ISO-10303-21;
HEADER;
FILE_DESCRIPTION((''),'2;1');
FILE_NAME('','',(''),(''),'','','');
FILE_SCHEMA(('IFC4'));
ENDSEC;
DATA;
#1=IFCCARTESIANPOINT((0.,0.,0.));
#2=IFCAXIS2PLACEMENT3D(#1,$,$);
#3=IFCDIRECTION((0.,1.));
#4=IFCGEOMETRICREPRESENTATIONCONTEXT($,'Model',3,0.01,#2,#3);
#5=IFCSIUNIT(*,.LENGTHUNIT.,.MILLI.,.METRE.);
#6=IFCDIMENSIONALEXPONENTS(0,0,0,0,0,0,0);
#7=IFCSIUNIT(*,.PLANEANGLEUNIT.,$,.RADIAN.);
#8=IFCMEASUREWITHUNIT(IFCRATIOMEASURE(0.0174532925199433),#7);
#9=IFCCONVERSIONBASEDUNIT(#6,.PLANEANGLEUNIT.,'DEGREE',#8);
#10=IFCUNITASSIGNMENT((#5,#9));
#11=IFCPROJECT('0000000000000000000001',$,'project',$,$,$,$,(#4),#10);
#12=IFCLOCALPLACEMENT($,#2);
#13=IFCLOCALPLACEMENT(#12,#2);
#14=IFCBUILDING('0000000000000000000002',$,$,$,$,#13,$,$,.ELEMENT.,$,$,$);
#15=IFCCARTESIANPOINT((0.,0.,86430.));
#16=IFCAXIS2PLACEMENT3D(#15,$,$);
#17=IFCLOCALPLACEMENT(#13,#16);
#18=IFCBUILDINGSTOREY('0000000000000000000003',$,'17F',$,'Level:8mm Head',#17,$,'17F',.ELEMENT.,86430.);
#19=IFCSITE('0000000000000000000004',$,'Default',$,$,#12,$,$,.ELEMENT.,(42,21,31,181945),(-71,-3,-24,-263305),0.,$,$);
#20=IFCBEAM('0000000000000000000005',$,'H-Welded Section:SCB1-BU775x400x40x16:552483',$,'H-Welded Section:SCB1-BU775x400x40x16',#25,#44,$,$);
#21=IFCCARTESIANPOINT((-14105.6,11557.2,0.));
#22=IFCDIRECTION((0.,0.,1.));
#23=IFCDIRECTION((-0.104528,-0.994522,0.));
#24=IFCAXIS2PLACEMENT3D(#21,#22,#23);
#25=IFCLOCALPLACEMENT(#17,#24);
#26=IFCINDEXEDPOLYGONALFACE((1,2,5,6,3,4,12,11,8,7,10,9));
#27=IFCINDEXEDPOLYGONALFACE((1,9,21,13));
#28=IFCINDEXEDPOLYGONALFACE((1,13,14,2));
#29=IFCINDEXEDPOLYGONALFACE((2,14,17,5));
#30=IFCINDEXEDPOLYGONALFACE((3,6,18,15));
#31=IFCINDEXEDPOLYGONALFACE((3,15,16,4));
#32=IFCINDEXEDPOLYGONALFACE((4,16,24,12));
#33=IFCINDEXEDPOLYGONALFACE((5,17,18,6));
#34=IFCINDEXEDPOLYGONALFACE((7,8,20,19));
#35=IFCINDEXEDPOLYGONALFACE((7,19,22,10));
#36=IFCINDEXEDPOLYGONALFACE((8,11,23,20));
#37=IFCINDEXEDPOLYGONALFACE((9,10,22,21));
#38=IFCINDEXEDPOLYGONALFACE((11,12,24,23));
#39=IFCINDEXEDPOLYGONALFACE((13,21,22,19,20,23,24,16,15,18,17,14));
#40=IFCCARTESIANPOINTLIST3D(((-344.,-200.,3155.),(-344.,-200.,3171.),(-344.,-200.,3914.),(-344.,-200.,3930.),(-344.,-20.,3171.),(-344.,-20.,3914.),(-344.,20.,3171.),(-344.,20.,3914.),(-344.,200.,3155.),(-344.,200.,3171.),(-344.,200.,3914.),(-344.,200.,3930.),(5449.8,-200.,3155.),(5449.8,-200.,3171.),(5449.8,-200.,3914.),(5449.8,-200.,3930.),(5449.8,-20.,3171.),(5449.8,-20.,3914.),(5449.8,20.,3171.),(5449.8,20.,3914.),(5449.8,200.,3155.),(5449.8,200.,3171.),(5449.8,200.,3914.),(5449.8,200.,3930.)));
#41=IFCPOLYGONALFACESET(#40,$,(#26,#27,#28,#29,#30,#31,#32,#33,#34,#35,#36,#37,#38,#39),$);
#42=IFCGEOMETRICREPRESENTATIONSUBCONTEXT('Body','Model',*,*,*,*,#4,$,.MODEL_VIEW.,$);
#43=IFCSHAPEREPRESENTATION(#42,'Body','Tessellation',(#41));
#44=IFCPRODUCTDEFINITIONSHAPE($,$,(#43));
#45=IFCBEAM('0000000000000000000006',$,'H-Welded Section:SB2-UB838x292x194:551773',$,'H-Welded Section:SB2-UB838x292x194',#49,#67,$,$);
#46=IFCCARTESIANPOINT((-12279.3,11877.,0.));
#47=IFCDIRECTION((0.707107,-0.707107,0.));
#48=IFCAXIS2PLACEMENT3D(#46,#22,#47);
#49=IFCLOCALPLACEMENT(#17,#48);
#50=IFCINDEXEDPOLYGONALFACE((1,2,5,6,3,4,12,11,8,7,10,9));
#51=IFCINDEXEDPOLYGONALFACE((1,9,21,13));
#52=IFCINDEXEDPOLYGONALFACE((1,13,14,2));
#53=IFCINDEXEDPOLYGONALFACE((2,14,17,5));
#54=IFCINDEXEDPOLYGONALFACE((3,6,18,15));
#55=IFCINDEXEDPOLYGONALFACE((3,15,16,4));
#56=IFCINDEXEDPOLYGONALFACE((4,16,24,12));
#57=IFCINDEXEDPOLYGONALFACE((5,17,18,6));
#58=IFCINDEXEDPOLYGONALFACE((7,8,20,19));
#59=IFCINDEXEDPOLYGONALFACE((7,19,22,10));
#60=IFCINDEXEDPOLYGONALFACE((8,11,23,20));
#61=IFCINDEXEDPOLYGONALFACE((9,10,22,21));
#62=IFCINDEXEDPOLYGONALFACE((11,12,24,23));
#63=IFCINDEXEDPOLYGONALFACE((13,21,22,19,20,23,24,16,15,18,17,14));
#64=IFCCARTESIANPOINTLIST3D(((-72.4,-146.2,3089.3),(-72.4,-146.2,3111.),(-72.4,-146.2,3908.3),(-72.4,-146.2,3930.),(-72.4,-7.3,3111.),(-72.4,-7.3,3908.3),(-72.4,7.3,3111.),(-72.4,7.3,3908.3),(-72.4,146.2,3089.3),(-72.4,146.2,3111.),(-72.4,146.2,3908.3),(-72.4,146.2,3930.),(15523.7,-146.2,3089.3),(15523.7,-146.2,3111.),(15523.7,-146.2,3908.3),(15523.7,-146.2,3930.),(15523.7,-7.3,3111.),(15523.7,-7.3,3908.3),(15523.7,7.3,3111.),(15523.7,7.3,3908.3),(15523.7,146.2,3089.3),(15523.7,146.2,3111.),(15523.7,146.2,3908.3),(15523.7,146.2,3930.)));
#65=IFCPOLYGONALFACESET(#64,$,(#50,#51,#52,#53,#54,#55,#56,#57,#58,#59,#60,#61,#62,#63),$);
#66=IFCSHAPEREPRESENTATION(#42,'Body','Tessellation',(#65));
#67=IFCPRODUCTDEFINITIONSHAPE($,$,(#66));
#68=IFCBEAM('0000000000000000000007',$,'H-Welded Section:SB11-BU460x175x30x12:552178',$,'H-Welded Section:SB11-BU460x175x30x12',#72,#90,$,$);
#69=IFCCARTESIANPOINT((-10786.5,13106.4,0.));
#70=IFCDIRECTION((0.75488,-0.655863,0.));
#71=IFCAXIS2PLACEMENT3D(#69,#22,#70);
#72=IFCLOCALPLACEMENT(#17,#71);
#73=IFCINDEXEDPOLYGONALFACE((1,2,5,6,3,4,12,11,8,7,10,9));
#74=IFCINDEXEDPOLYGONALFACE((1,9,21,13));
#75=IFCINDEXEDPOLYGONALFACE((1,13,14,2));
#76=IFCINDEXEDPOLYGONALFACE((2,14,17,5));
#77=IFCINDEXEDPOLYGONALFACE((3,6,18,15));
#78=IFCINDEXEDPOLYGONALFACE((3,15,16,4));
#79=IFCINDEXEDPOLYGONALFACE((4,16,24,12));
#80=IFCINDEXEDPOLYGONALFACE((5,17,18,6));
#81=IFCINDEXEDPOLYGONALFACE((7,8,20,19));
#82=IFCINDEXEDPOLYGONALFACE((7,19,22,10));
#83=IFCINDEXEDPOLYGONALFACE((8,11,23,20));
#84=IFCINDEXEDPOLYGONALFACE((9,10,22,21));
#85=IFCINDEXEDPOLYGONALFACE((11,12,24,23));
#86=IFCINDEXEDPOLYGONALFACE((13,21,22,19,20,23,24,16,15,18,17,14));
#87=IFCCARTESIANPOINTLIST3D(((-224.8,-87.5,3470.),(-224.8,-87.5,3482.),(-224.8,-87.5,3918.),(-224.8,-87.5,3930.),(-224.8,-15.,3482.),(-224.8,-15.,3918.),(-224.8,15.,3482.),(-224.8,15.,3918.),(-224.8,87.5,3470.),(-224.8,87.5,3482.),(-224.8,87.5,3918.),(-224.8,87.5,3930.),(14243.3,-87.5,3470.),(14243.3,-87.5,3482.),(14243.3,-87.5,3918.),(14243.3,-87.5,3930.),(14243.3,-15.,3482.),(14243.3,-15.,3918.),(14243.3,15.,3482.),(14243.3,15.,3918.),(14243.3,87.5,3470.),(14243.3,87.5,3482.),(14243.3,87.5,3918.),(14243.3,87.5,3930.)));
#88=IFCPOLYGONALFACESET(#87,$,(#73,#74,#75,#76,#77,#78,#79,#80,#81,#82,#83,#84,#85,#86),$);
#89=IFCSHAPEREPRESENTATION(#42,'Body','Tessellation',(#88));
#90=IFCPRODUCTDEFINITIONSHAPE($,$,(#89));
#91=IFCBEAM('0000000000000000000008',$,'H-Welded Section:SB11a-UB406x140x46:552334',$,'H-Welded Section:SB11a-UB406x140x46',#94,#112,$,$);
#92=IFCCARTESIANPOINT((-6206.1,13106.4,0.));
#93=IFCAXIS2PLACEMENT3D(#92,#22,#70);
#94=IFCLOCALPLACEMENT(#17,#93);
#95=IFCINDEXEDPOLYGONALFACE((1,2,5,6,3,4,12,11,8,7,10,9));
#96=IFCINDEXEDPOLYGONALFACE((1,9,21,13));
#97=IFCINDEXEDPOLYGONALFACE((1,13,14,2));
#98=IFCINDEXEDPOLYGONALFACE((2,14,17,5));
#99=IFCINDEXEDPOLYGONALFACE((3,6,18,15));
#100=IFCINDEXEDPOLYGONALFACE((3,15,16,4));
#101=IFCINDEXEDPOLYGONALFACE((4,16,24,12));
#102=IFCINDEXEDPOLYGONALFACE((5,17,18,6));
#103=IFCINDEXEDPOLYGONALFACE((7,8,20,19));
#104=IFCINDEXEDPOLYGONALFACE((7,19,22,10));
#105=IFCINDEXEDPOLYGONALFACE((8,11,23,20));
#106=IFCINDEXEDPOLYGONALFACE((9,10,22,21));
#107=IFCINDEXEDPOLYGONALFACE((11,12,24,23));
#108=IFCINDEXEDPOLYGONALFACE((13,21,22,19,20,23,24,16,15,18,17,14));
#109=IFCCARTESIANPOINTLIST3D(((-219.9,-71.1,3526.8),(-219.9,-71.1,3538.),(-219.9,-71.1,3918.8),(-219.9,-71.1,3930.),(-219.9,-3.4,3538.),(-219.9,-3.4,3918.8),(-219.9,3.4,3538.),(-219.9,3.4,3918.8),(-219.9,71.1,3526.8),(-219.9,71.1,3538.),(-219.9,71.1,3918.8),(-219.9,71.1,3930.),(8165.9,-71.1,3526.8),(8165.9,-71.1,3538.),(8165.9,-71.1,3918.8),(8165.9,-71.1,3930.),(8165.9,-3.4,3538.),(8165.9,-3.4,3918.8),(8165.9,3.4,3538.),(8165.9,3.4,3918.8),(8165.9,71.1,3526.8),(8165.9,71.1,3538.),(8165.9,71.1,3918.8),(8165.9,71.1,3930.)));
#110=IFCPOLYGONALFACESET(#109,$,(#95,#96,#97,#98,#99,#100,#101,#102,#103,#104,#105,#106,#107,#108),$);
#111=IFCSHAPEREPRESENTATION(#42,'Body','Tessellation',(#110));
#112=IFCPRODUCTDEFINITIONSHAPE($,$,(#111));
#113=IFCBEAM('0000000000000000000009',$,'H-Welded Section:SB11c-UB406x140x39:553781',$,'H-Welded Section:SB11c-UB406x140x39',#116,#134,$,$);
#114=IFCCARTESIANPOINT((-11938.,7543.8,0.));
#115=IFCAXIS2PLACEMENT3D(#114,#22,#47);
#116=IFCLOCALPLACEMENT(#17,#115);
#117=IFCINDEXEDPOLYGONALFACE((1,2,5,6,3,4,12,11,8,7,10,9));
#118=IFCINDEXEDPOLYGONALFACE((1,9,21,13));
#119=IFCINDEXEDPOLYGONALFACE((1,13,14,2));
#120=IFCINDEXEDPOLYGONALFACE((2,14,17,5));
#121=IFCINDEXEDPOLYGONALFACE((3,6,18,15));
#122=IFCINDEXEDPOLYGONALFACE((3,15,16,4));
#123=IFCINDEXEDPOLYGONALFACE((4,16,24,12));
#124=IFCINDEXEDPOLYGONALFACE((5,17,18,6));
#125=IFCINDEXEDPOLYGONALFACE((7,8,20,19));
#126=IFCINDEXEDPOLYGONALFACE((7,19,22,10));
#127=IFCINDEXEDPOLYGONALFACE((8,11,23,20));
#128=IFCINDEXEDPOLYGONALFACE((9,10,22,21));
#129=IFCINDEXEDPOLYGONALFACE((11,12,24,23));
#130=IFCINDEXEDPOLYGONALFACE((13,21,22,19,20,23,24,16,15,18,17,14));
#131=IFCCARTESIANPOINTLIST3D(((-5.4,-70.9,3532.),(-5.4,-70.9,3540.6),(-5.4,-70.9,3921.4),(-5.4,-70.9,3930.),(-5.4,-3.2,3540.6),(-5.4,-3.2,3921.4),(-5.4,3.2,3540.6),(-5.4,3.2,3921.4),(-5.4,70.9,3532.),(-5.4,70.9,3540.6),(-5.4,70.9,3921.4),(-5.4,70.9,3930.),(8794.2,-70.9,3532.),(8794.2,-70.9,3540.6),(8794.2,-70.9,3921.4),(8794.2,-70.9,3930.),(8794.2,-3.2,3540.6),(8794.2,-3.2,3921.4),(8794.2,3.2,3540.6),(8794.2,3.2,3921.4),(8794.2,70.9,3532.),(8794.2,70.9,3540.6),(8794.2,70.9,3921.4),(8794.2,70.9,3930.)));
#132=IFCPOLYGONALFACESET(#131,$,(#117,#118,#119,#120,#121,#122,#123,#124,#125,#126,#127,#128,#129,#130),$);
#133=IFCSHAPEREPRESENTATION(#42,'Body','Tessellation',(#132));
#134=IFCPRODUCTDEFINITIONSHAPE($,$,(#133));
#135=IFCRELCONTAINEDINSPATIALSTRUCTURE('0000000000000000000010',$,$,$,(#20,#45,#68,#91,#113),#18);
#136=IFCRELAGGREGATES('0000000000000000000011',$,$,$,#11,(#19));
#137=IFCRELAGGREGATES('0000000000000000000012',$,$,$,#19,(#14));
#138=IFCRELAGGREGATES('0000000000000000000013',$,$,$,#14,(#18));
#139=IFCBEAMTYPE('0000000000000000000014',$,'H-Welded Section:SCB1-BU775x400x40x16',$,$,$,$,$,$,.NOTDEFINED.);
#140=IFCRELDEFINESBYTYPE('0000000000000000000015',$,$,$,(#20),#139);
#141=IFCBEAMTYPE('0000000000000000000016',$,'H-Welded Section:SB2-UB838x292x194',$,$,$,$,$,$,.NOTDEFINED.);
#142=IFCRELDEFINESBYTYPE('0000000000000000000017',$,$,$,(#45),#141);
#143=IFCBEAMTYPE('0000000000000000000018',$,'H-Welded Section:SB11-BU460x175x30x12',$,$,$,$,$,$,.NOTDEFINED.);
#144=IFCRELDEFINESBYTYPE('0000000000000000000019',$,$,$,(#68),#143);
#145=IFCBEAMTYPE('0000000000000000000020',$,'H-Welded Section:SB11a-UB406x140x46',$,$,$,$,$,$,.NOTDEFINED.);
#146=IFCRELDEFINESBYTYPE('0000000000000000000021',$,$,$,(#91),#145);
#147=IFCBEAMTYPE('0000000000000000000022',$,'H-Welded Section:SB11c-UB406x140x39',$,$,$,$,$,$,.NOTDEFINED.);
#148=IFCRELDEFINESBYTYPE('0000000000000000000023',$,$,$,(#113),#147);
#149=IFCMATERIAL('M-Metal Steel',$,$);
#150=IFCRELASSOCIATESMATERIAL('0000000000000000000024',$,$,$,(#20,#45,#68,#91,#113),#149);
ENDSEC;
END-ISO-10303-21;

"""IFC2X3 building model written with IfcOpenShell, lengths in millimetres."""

from ifc_helpers import new_model, entity, si_unit, converted_unit, direction, frame, frame_2d, origin, place, context, subcontext, project, spatial, i_section, extrude, material, type_object, element, save


model = new_model("IFC2X3")

# Units and contexts
model_context = context("Model", 3, precision=0.01, world=origin(), true_north=direction((0.0, 1.0)))
body_context = subcontext(model_context, "Body", "Model", "MODEL_VIEW")
ifc_project = project(units=[si_unit("LENGTHUNIT", "METRE", prefix="MILLI"), converted_unit("PLANEANGLEUNIT", "DEGREE", entity("IfcRatioMeasure", 0.0174532925199433), si_unit("PLANEANGLEUNIT", "RADIAN"), dimensions=[0, 0, 0, 0, 0, 0, 0])], contexts=[model_context])

# Site, building, storey
site_placement = place(None, origin())
site = spatial("IfcSite", under=ifc_project, at=site_placement, Name="Default", CompositionType="ELEMENT", RefLatitude=(42, 21, 31, 181945), RefLongitude=(-71, -3, -24, -263305), RefElevation=0.0)
building_placement = place(site_placement, origin())
building = spatial("IfcBuilding", under=site, at=building_placement, CompositionType="ELEMENT")
storey_placement = place(building_placement, frame((0.0, 0.0, 86430.0)))
storey = spatial("IfcBuildingStorey", under=building, at=storey_placement, Name="17F", ObjectType="Level:8mm Head", LongName="17F", CompositionType="ELEMENT", Elevation=86430.0)

# Beams
ifc_material_1 = material(Name="M-Metal Steel")
beam_type_1 = type_object("IfcBeamType", Name="H-Welded Section:SCB1-BU775x400x40x16", PredefinedType="NOTDEFINED")
beam_1_placement = place(storey_placement, frame((-14105.6, 11557.2, 0.0), z_axis=(0.0, 0.0, 1.0), x_axis=(-0.104528, -0.994522, 0.0)))
element("IfcBeam", 1, at=beam_1_placement, inside=storey, type_object=beam_type_1, material=ifc_material_1, Name="H-Welded Section:SCB1-BU775x400x40x16:552483", ObjectType="H-Welded Section:SCB1-BU775x400x40x16", context=body_context, shape_type="SweptSolid", body=[
    extrude(i_section(OverallWidth=400.0, OverallDepth=775.0, WebThickness=40.0, FlangeThickness=16.0, at=frame_2d((0.0, 0.0), x_axis=(0.0, 1.0))), frame((-344.0, 0.0, 3542.5), z_axis=(1.0, 0.0, 0.0), x_axis=(0.0, 0.0, -1.0)), (0.0, 0.0, 1.0), 5793.8),
])
beam_type_2 = type_object("IfcBeamType", Name="H-Welded Section:SB2-UB838x292x194", PredefinedType="NOTDEFINED")
beam_2_placement = place(storey_placement, frame((-12279.3, 11877.0, 0.0), z_axis=(0.0, 0.0, 1.0), x_axis=(0.707107, -0.707107, 0.0)))
element("IfcBeam", 2, at=beam_2_placement, inside=storey, type_object=beam_type_2, material=ifc_material_1, Name="H-Welded Section:SB2-UB838x292x194:551773", ObjectType="H-Welded Section:SB2-UB838x292x194", context=body_context, shape_type="SweptSolid", body=[
    extrude(i_section(OverallWidth=292.4, OverallDepth=840.7, WebThickness=14.7, FlangeThickness=21.7, at=frame_2d((0.0, 0.0), x_axis=(0.0, 1.0))), frame((-72.4, 0.0, 3509.6), z_axis=(1.0, 0.0, 0.0), x_axis=(0.0, 0.0, -1.0)), (0.0, 0.0, 1.0), 15596.1),
])
beam_type_3 = type_object("IfcBeamType", Name="H-Welded Section:SB11-BU460x175x30x12", PredefinedType="NOTDEFINED")
beam_3_placement = place(storey_placement, frame((-10786.5, 13106.4, 0.0), z_axis=(0.0, 0.0, 1.0), x_axis=(0.75488, -0.655863, 0.0)))
element("IfcBeam", 3, at=beam_3_placement, inside=storey, type_object=beam_type_3, material=ifc_material_1, Name="H-Welded Section:SB11-BU460x175x30x12:552178", ObjectType="H-Welded Section:SB11-BU460x175x30x12", context=body_context, shape_type="SweptSolid", body=[
    extrude(i_section(OverallWidth=175.0, OverallDepth=460.0, WebThickness=30.0, FlangeThickness=12.0, at=frame_2d((0.0, 0.0), x_axis=(0.0, 1.0))), frame((-224.8, 0.0, 3700.0), z_axis=(1.0, 0.0, 0.0), x_axis=(0.0, 0.0, -1.0)), (0.0, 0.0, 1.0), 14468.1),
])
beam_type_4 = type_object("IfcBeamType", Name="H-Welded Section:SB11a-UB406x140x46", PredefinedType="NOTDEFINED")
beam_4_placement = place(storey_placement, frame((-6206.1, 13106.4, 0.0), z_axis=(0.0, 0.0, 1.0), x_axis=(0.75488, -0.655863, 0.0)))
element("IfcBeam", 4, at=beam_4_placement, inside=storey, type_object=beam_type_4, material=ifc_material_1, Name="H-Welded Section:SB11a-UB406x140x46:552334", ObjectType="H-Welded Section:SB11a-UB406x140x46", context=body_context, shape_type="SweptSolid", body=[
    extrude(i_section(OverallWidth=142.2, OverallDepth=403.2, WebThickness=6.8, FlangeThickness=11.2, at=frame_2d((0.0, 0.0), x_axis=(0.0, 1.0))), frame((-219.9, 0.0, 3728.4), z_axis=(1.0, 0.0, 0.0), x_axis=(0.0, 0.0, -1.0)), (0.0, 0.0, 1.0), 8385.8),
])
beam_type_5 = type_object("IfcBeamType", Name="H-Welded Section:SB11c-UB406x140x39", PredefinedType="NOTDEFINED")
beam_5_placement = place(storey_placement, frame((-11938.0, 7543.8, 0.0), z_axis=(0.0, 0.0, 1.0), x_axis=(0.707107, -0.707107, 0.0)))
element("IfcBeam", 5, at=beam_5_placement, inside=storey, type_object=beam_type_5, material=ifc_material_1, Name="H-Welded Section:SB11c-UB406x140x39:553781", ObjectType="H-Welded Section:SB11c-UB406x140x39", context=body_context, shape_type="SweptSolid", body=[
    extrude(i_section(OverallWidth=141.8, OverallDepth=398.0, WebThickness=6.4, FlangeThickness=8.6, at=frame_2d((0.0, 0.0), x_axis=(0.0, 1.0))), frame((-5.4, 0.0, 3731.0), z_axis=(1.0, 0.0, 0.0), x_axis=(0.0, 0.0, -1.0)), (0.0, 0.0, 1.0), 8799.6),
])

save(model, "model.ifc")
